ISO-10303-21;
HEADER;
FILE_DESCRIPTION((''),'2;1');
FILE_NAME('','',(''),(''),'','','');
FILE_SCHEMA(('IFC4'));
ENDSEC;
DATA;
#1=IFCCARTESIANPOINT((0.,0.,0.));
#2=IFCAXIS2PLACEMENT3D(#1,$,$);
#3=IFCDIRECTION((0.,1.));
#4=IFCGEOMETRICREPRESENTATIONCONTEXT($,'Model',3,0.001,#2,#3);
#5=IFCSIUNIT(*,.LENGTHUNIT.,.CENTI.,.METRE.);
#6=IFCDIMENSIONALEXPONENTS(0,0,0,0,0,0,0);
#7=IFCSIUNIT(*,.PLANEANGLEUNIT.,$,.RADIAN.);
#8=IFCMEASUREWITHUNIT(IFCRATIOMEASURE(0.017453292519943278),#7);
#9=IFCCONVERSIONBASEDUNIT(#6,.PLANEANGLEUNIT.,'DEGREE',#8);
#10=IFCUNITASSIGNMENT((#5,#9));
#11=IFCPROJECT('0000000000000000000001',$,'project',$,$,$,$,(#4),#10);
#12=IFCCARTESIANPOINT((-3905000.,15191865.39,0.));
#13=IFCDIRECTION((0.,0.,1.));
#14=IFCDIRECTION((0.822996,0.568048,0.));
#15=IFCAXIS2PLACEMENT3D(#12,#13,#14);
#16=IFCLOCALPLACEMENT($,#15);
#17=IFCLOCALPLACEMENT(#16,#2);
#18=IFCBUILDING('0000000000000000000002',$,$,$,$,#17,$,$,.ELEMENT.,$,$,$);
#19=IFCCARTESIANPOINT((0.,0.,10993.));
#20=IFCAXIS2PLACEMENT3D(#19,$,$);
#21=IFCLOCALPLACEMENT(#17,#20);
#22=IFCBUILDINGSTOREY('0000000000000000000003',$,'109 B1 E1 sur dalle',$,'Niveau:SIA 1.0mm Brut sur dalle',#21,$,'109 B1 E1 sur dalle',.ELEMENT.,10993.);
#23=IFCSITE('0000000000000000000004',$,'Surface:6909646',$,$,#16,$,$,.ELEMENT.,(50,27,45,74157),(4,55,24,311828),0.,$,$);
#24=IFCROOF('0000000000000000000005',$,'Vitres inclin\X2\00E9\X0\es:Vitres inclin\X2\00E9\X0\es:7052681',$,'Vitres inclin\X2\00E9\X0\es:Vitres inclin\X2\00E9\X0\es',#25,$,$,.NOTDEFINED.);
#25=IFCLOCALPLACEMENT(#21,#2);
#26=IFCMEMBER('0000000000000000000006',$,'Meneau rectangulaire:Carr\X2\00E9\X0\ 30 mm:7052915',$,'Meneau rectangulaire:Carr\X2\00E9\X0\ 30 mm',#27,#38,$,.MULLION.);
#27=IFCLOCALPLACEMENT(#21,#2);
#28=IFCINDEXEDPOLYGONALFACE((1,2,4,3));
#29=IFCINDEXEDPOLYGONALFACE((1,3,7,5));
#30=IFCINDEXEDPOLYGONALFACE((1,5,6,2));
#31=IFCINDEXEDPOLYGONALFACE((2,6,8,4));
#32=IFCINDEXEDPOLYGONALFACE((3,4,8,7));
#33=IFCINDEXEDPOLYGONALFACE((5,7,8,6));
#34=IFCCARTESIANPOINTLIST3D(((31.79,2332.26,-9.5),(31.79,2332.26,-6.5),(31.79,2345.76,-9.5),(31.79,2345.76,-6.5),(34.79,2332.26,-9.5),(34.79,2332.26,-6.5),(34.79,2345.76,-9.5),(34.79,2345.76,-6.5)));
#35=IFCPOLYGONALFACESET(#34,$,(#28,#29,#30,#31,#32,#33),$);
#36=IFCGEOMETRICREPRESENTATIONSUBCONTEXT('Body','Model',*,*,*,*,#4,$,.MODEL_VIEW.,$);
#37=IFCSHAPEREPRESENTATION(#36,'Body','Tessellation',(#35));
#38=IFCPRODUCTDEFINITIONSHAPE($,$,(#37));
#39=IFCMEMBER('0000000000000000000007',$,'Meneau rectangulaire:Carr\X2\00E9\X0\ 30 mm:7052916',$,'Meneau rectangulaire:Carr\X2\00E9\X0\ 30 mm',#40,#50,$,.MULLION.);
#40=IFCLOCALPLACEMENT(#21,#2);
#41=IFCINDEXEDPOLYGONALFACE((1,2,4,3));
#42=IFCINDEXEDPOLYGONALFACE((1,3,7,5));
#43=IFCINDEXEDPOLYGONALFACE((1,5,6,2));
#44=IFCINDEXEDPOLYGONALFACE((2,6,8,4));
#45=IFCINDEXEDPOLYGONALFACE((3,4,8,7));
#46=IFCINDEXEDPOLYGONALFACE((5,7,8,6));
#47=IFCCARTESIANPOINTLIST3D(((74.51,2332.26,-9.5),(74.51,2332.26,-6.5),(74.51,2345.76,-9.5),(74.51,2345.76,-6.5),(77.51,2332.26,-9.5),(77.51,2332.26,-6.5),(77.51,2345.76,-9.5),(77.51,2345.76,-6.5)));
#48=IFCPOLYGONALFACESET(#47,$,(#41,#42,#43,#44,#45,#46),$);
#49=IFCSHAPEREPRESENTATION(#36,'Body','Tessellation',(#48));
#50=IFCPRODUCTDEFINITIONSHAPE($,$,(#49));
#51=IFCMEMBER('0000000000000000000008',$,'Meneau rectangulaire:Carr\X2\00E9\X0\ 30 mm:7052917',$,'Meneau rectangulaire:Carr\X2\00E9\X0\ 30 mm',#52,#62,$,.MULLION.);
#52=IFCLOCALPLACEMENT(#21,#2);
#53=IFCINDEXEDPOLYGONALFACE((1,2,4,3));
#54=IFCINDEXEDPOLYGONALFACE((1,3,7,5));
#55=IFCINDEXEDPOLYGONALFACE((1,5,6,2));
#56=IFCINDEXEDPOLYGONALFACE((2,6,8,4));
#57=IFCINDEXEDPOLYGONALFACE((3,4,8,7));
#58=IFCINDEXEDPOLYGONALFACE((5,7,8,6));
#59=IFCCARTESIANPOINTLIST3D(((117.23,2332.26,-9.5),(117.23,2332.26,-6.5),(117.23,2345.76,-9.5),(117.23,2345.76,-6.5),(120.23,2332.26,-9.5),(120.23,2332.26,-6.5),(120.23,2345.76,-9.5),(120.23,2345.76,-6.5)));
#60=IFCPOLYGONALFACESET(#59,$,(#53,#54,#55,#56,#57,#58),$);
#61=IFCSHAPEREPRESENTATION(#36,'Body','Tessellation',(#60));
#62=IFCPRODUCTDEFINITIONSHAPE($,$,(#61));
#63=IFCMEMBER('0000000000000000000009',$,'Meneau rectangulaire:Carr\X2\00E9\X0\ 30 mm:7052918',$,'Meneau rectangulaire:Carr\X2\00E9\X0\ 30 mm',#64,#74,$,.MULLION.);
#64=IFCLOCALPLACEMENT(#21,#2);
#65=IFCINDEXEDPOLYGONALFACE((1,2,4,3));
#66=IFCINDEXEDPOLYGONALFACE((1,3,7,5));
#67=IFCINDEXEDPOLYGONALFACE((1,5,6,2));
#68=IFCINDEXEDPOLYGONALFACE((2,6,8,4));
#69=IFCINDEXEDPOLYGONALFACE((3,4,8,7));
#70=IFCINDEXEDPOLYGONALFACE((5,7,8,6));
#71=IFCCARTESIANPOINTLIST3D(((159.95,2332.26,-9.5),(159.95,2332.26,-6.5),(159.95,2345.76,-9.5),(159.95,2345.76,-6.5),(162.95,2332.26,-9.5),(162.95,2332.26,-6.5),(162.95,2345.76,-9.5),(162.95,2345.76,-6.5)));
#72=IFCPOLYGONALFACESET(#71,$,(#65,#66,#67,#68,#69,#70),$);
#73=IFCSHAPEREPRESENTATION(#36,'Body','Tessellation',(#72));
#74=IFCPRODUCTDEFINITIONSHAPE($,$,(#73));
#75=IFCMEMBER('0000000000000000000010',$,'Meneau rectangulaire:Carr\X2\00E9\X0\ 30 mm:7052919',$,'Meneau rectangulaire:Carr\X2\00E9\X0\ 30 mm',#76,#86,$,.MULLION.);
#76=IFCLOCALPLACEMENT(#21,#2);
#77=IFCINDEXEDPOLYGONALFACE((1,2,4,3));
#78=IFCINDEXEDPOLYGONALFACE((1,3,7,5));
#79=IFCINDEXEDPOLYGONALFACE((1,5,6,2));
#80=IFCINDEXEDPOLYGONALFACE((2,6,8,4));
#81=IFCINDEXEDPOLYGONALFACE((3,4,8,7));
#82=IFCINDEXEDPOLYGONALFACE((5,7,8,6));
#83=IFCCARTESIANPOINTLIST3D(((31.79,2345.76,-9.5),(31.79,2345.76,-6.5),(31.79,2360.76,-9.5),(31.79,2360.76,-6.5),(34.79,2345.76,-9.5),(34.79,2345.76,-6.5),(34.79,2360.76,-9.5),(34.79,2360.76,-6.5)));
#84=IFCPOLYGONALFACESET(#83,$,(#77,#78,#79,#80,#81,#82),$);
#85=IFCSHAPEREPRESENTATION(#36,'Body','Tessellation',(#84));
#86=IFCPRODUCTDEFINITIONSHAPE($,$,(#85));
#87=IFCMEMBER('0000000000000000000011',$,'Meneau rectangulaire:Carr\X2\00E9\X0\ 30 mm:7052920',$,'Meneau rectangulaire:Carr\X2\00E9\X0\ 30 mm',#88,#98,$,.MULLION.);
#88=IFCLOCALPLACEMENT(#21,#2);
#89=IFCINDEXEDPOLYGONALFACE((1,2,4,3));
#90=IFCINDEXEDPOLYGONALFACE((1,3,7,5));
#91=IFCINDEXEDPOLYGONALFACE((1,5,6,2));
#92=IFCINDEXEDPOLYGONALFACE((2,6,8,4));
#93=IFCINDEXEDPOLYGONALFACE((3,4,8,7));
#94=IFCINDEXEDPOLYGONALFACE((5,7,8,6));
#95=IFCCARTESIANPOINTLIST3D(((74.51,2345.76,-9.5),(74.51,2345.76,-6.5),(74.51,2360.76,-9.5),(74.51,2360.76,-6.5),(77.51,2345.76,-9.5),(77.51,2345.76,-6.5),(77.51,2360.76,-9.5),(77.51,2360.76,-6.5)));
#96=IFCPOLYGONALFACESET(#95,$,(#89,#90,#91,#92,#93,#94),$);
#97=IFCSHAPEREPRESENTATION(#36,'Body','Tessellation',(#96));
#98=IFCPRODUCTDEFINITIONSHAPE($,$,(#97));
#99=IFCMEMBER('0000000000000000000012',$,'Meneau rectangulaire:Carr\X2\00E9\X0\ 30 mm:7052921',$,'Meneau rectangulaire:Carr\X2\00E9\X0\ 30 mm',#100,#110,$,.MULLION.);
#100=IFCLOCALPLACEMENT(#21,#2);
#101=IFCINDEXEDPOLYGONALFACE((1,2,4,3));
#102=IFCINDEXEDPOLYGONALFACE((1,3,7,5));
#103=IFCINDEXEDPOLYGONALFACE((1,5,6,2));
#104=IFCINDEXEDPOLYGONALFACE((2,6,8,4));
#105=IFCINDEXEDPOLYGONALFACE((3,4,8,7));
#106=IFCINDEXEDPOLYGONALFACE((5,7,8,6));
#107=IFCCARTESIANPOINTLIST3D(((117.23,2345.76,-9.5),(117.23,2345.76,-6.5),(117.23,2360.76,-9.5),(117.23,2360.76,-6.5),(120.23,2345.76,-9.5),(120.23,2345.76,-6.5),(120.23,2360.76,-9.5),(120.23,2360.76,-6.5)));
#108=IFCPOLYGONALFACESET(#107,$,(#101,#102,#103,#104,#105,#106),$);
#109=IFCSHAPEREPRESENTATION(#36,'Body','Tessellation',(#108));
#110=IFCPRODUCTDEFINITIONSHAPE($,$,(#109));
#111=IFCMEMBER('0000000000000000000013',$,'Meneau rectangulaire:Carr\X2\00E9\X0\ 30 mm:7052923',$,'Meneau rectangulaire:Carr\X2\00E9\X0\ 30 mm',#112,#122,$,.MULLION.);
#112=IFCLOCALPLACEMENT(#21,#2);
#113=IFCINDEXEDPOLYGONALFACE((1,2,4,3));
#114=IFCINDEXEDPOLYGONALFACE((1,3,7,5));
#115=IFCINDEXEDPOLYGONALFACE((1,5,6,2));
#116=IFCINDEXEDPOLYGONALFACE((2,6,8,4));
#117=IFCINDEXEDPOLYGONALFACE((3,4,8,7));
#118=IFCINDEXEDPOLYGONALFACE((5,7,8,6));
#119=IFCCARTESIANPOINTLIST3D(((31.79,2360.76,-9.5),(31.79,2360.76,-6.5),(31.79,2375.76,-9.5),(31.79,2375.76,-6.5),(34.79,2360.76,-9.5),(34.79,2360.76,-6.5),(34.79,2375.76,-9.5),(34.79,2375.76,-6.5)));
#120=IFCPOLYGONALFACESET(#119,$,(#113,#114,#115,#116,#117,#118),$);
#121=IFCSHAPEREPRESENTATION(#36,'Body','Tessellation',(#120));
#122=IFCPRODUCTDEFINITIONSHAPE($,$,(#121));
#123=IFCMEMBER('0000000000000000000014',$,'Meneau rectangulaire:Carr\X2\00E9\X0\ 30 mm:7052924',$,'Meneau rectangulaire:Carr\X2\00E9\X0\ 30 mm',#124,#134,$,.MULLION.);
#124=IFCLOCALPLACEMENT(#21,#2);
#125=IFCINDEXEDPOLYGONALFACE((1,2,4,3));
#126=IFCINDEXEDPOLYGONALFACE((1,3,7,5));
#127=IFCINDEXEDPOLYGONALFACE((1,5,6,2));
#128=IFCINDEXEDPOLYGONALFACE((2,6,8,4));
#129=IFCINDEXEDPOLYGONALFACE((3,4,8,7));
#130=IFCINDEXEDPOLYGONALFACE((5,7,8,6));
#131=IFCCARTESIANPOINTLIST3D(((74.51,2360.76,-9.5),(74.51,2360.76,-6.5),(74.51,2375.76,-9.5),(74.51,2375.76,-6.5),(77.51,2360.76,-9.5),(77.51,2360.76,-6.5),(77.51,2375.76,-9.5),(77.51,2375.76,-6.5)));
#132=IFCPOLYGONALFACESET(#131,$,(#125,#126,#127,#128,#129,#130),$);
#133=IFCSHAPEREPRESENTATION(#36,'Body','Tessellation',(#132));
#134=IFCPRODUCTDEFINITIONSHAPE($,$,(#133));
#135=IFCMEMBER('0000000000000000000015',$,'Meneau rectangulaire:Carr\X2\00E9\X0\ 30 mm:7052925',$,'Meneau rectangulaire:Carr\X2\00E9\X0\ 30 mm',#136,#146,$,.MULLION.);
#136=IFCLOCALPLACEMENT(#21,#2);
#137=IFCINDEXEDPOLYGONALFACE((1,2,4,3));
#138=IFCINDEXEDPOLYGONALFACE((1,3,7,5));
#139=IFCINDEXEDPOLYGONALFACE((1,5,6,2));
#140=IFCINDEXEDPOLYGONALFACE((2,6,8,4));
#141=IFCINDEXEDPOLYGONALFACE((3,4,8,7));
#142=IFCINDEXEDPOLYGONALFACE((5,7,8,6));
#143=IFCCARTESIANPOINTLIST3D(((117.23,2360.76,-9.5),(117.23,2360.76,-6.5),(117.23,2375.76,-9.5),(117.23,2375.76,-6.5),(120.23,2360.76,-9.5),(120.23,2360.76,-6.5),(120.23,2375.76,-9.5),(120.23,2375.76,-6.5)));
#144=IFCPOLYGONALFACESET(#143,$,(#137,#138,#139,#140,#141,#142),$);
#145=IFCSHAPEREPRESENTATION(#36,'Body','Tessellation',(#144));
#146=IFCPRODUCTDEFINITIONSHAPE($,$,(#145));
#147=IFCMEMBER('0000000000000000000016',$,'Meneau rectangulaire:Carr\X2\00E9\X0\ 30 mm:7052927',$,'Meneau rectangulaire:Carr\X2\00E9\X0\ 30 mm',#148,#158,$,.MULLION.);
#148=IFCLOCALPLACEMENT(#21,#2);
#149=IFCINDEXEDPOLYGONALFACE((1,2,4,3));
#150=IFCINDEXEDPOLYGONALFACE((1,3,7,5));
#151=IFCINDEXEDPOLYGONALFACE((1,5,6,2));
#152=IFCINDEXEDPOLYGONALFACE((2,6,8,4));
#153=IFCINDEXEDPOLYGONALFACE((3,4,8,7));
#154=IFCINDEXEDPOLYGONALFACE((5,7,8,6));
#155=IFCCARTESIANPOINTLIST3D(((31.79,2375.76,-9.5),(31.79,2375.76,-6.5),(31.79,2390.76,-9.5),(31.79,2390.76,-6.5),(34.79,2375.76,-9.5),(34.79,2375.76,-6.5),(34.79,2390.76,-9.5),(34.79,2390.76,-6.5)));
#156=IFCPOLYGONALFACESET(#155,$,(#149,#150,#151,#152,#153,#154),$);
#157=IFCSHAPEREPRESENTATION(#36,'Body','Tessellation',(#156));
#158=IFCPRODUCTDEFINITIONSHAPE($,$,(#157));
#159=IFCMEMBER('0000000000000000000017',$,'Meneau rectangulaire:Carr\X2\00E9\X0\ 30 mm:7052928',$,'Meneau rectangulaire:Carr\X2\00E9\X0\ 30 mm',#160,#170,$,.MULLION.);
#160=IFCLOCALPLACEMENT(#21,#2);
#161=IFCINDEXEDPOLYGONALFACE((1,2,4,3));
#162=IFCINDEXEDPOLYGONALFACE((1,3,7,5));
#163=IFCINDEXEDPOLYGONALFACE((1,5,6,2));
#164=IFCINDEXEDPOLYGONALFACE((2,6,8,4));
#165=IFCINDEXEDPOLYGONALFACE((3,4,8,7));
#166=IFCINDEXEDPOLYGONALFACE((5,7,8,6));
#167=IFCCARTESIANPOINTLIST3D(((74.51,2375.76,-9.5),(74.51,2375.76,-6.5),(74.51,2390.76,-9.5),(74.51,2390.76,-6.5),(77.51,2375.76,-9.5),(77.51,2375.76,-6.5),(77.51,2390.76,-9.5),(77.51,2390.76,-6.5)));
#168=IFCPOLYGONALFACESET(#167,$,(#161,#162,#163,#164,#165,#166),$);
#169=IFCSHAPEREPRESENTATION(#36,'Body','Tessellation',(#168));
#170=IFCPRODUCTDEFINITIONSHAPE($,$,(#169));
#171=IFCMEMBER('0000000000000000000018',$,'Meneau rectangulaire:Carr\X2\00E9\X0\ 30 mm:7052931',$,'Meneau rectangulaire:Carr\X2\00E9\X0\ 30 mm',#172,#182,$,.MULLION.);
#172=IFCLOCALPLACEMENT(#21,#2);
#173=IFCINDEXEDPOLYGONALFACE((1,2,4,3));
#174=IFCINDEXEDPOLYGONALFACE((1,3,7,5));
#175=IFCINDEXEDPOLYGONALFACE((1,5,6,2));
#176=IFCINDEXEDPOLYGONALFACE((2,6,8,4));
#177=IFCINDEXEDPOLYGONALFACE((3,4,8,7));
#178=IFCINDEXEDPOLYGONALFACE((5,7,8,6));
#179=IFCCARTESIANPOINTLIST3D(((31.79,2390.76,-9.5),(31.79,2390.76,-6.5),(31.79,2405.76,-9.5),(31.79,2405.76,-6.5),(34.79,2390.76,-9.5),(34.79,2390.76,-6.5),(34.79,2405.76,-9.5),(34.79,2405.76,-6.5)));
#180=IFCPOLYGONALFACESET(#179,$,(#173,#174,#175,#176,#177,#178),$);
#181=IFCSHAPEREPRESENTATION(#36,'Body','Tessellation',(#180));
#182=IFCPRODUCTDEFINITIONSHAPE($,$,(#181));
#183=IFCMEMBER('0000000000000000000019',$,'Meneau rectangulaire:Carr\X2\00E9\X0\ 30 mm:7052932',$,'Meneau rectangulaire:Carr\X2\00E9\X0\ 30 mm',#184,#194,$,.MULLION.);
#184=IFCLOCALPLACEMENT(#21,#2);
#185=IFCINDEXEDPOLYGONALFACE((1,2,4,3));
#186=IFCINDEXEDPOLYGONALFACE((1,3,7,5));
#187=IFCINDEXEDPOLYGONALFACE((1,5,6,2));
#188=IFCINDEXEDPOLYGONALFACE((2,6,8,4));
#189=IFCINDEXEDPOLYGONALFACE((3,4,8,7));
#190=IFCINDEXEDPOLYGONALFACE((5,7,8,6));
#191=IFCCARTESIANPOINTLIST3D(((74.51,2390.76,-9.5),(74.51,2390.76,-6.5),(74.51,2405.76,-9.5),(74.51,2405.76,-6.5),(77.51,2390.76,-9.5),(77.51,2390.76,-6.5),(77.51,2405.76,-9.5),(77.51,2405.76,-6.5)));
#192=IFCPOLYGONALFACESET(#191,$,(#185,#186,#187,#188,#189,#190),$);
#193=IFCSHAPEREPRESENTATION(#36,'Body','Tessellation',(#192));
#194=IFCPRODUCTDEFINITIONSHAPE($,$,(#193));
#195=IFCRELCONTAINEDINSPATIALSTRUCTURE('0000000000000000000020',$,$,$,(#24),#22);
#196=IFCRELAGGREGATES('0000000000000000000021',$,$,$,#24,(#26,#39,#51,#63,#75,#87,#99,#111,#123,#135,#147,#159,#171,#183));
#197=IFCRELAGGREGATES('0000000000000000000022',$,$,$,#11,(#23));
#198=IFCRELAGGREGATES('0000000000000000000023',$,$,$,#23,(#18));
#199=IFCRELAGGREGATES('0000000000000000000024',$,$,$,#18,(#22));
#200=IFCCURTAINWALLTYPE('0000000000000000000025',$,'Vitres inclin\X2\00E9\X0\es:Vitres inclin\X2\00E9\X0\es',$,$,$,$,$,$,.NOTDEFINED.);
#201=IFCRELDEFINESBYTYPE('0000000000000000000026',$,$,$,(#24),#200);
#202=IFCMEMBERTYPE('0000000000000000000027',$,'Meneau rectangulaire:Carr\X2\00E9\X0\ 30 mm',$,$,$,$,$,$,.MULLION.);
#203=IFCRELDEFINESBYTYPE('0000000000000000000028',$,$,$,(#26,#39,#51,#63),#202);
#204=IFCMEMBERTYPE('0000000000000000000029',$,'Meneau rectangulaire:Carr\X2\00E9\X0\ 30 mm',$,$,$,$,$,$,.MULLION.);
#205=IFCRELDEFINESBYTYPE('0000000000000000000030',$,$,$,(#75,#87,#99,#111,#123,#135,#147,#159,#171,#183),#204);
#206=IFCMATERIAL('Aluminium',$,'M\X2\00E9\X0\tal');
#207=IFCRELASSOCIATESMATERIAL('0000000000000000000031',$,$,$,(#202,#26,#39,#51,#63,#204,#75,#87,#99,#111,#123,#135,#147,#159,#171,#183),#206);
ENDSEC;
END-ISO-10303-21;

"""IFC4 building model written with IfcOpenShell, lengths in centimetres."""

from ifc_helpers import new_model, entity, si_unit, converted_unit, direction, frame, origin, place, context, subcontext, project, spatial, indexed_curve, outline, extrude, source, transform, mapped, material, type_object, type_shapes, element, aggregate, save


model = new_model("IFC4")

# Units and contexts
model_context = context("Model", 3, precision=0.001, world=origin(), true_north=direction((0.0, 1.0)))
body_context = subcontext(model_context, "Body", "Model", "MODEL_VIEW")
ifc_project = project(units=[si_unit("LENGTHUNIT", "METRE", prefix="CENTI"), converted_unit("PLANEANGLEUNIT", "DEGREE", entity("IfcRatioMeasure", 0.017453292519943278), si_unit("PLANEANGLEUNIT", "RADIAN"), dimensions=[0, 0, 0, 0, 0, 0, 0])], contexts=[model_context])

# Site, building, storey
site_placement = place(None, frame((-3905000.0, 15191865.39, 0.0), z_axis=(0.0, 0.0, 1.0), x_axis=(0.822996, 0.568048, 0.0)))
site = spatial("IfcSite", under=ifc_project, at=site_placement, Name="Surface:6909646", CompositionType="ELEMENT", RefLatitude=(50, 27, 45, 74157), RefLongitude=(4, 55, 24, 311828), RefElevation=0.0)
building_placement = place(site_placement, origin())
building = spatial("IfcBuilding", under=site, at=building_placement, CompositionType="ELEMENT")
storey_placement = place(building_placement, frame((0.0, 0.0, 10993.0)))
storey = spatial("IfcBuildingStorey", under=building, at=storey_placement, Name="109 B1 E1 sur dalle", ObjectType="Niveau:SIA 1.0mm Brut sur dalle", LongName="109 B1 E1 sur dalle", CompositionType="ELEMENT", Elevation=10993.0)

# Roof, members
curtain_wall_type = type_object("IfcCurtainWallType", Name="Vitres inclinées:Vitres inclinées", PredefinedType="NOTDEFINED")
roof_placement = place(storey_placement, frame((0.0, 0.0, -10993.0)))
roof = element("IfcRoof", 1, at=roof_placement, inside=storey, type_object=curtain_wall_type, Name="Vitres inclinées:Vitres inclinées:7052681", ObjectType="Vitres inclinées:Vitres inclinées", PredefinedType="NOTDEFINED")
ifc_material = material(Name="Aluminium", Category="Métal")
member_type_1 = type_object("IfcMemberType", Name="Meneau rectangulaire:Carré 30 mm", PredefinedType="MULLION", material=ifc_material)
shared_shape_1 = source(origin(), body_context, "Body", "SweptSolid", [
    extrude(outline(indexed_curve([(-1.5, -1.5), (1.5, -1.5), (1.5, 1.5), (-1.5, 1.5), (-1.5, -1.5)], self_intersect=False)), frame((0.0, 0.0, -13.5), z_axis=(0.0, 0.0, 1.0), x_axis=(0.0, -1.0, 0.0)), (0.0, 0.0, 1.0), 13.5),
])
type_shapes(member_type_1, [shared_shape_1])
member_1_placement = place(roof_placement, frame((33.29, 2345.76, 10985.0), z_axis=(0.0, 1.0, 0.0), x_axis=(1.0, 0.0, 0.0)))
member_1 = element("IfcMember", 2, at=member_1_placement, type_object=member_type_1, material=ifc_material, Name="Meneau rectangulaire:Carré 30 mm:7052915", ObjectType="Meneau rectangulaire:Carré 30 mm", PredefinedType="MULLION", context=body_context, shape_type="MappedRepresentation", body=[
    mapped(shared_shape_1, transform((0.0, 0.0, 0.0), scale=1.0)),
])
member_2_placement = place(roof_placement, frame((76.01, 2345.76, 10985.0), z_axis=(0.0, 1.0, 0.0), x_axis=(1.0, 0.0, 0.0)))
member_2 = element("IfcMember", 3, at=member_2_placement, type_object=member_type_1, material=ifc_material, Name="Meneau rectangulaire:Carré 30 mm:7052916", ObjectType="Meneau rectangulaire:Carré 30 mm", PredefinedType="MULLION", context=body_context, shape_type="MappedRepresentation", body=[
    mapped(shared_shape_1, transform((0.0, 0.0, 0.0), scale=1.0)),
])
member_3_placement = place(roof_placement, frame((118.73, 2345.76, 10985.0), z_axis=(0.0, 1.0, 0.0), x_axis=(1.0, 0.0, 0.0)))
member_3 = element("IfcMember", 4, at=member_3_placement, type_object=member_type_1, material=ifc_material, Name="Meneau rectangulaire:Carré 30 mm:7052917", ObjectType="Meneau rectangulaire:Carré 30 mm", PredefinedType="MULLION", context=body_context, shape_type="MappedRepresentation", body=[
    mapped(shared_shape_1, transform((0.0, 0.0, 0.0), scale=1.0)),
])
member_4_placement = place(roof_placement, frame((161.45, 2345.76, 10985.0), z_axis=(0.0, 1.0, 0.0), x_axis=(1.0, 0.0, 0.0)))
member_4 = element("IfcMember", 5, at=member_4_placement, type_object=member_type_1, material=ifc_material, Name="Meneau rectangulaire:Carré 30 mm:7052918", ObjectType="Meneau rectangulaire:Carré 30 mm", PredefinedType="MULLION", context=body_context, shape_type="MappedRepresentation", body=[
    mapped(shared_shape_1, transform((0.0, 0.0, 0.0), scale=1.0)),
])
member_type_2 = type_object("IfcMemberType", Name="Meneau rectangulaire:Carré 30 mm", PredefinedType="MULLION", material=ifc_material)
shared_shape_2 = source(origin(), body_context, "Body", "SweptSolid", [
    extrude(outline(indexed_curve([(-1.5, -1.5), (1.5, -1.5), (1.5, 1.5), (-1.5, 1.5), (-1.5, -1.5)], self_intersect=False)), frame((0.0, 0.0, -15.0), z_axis=(0.0, 0.0, 1.0), x_axis=(0.0, -1.0, 0.0)), (0.0, 0.0, 1.0), 15.0),
])
type_shapes(member_type_2, [shared_shape_2])
member_5_placement = place(roof_placement, frame((33.29, 2360.76, 10985.0), z_axis=(0.0, 1.0, 0.0), x_axis=(1.0, 0.0, 0.0)))
member_5 = element("IfcMember", 6, at=member_5_placement, type_object=member_type_2, material=ifc_material, Name="Meneau rectangulaire:Carré 30 mm:7052919", ObjectType="Meneau rectangulaire:Carré 30 mm", PredefinedType="MULLION", context=body_context, shape_type="MappedRepresentation", body=[
    mapped(shared_shape_2, transform((0.0, 0.0, 0.0), scale=1.0)),
])
member_6_placement = place(roof_placement, frame((76.01, 2360.76, 10985.0), z_axis=(0.0, 1.0, 0.0), x_axis=(1.0, 0.0, 0.0)))
member_6 = element("IfcMember", 7, at=member_6_placement, type_object=member_type_2, material=ifc_material, Name="Meneau rectangulaire:Carré 30 mm:7052920", ObjectType="Meneau rectangulaire:Carré 30 mm", PredefinedType="MULLION", context=body_context, shape_type="MappedRepresentation", body=[
    mapped(shared_shape_2, transform((0.0, 0.0, 0.0), scale=1.0)),
])
member_7_placement = place(roof_placement, frame((118.73, 2360.76, 10985.0), z_axis=(0.0, 1.0, 0.0), x_axis=(1.0, 0.0, 0.0)))
member_7 = element("IfcMember", 8, at=member_7_placement, type_object=member_type_2, material=ifc_material, Name="Meneau rectangulaire:Carré 30 mm:7052921", ObjectType="Meneau rectangulaire:Carré 30 mm", PredefinedType="MULLION", context=body_context, shape_type="MappedRepresentation", body=[
    mapped(shared_shape_2, transform((0.0, 0.0, 0.0), scale=1.0)),
])
member_8_placement = place(roof_placement, frame((33.29, 2375.76, 10985.0), z_axis=(0.0, 1.0, 0.0), x_axis=(1.0, 0.0, 0.0)))
member_8 = element("IfcMember", 9, at=member_8_placement, type_object=member_type_2, material=ifc_material, Name="Meneau rectangulaire:Carré 30 mm:7052923", ObjectType="Meneau rectangulaire:Carré 30 mm", PredefinedType="MULLION", context=body_context, shape_type="MappedRepresentation", body=[
    mapped(shared_shape_2, transform((0.0, 0.0, 0.0), scale=1.0)),
])
member_9_placement = place(roof_placement, frame((76.01, 2375.76, 10985.0), z_axis=(0.0, 1.0, 0.0), x_axis=(1.0, 0.0, 0.0)))
member_9 = element("IfcMember", 10, at=member_9_placement, type_object=member_type_2, material=ifc_material, Name="Meneau rectangulaire:Carré 30 mm:7052924", ObjectType="Meneau rectangulaire:Carré 30 mm", PredefinedType="MULLION", context=body_context, shape_type="MappedRepresentation", body=[
    mapped(shared_shape_2, transform((0.0, 0.0, 0.0), scale=1.0)),
])
member_10_placement = place(roof_placement, frame((118.73, 2375.76, 10985.0), z_axis=(0.0, 1.0, 0.0), x_axis=(1.0, 0.0, 0.0)))
member_10 = element("IfcMember", 11, at=member_10_placement, type_object=member_type_2, material=ifc_material, Name="Meneau rectangulaire:Carré 30 mm:7052925", ObjectType="Meneau rectangulaire:Carré 30 mm", PredefinedType="MULLION", context=body_context, shape_type="MappedRepresentation", body=[
    mapped(shared_shape_2, transform((0.0, 0.0, 0.0), scale=1.0)),
])
member_11_placement = place(roof_placement, frame((33.29, 2390.76, 10985.0), z_axis=(0.0, 1.0, 0.0), x_axis=(1.0, 0.0, 0.0)))
member_11 = element("IfcMember", 12, at=member_11_placement, type_object=member_type_2, material=ifc_material, Name="Meneau rectangulaire:Carré 30 mm:7052927", ObjectType="Meneau rectangulaire:Carré 30 mm", PredefinedType="MULLION", context=body_context, shape_type="MappedRepresentation", body=[
    mapped(shared_shape_2, transform((0.0, 0.0, 0.0), scale=1.0)),
])
member_12_placement = place(roof_placement, frame((76.01, 2390.76, 10985.0), z_axis=(0.0, 1.0, 0.0), x_axis=(1.0, 0.0, 0.0)))
member_12 = element("IfcMember", 13, at=member_12_placement, type_object=member_type_2, material=ifc_material, Name="Meneau rectangulaire:Carré 30 mm:7052928", ObjectType="Meneau rectangulaire:Carré 30 mm", PredefinedType="MULLION", context=body_context, shape_type="MappedRepresentation", body=[
    mapped(shared_shape_2, transform((0.0, 0.0, 0.0), scale=1.0)),
])
member_13_placement = place(roof_placement, frame((33.29, 2405.76, 10985.0), z_axis=(0.0, 1.0, 0.0), x_axis=(1.0, 0.0, 0.0)))
member_13 = element("IfcMember", 14, at=member_13_placement, type_object=member_type_2, material=ifc_material, Name="Meneau rectangulaire:Carré 30 mm:7052931", ObjectType="Meneau rectangulaire:Carré 30 mm", PredefinedType="MULLION", context=body_context, shape_type="MappedRepresentation", body=[
    mapped(shared_shape_2, transform((0.0, 0.0, 0.0), scale=1.0)),
])
member_14_placement = place(roof_placement, frame((76.01, 2405.76, 10985.0), z_axis=(0.0, 1.0, 0.0), x_axis=(1.0, 0.0, 0.0)))
member_14 = element("IfcMember", 15, at=member_14_placement, type_object=member_type_2, material=ifc_material, Name="Meneau rectangulaire:Carré 30 mm:7052932", ObjectType="Meneau rectangulaire:Carré 30 mm", PredefinedType="MULLION", context=body_context, shape_type="MappedRepresentation", body=[
    mapped(shared_shape_2, transform((0.0, 0.0, 0.0), scale=1.0)),
])
aggregate(roof, [member_1, member_2, member_3, member_4, member_5, member_6, member_7, member_8, member_9, member_10, member_11, member_12, member_13, member_14])

save(model, "model.ifc")
